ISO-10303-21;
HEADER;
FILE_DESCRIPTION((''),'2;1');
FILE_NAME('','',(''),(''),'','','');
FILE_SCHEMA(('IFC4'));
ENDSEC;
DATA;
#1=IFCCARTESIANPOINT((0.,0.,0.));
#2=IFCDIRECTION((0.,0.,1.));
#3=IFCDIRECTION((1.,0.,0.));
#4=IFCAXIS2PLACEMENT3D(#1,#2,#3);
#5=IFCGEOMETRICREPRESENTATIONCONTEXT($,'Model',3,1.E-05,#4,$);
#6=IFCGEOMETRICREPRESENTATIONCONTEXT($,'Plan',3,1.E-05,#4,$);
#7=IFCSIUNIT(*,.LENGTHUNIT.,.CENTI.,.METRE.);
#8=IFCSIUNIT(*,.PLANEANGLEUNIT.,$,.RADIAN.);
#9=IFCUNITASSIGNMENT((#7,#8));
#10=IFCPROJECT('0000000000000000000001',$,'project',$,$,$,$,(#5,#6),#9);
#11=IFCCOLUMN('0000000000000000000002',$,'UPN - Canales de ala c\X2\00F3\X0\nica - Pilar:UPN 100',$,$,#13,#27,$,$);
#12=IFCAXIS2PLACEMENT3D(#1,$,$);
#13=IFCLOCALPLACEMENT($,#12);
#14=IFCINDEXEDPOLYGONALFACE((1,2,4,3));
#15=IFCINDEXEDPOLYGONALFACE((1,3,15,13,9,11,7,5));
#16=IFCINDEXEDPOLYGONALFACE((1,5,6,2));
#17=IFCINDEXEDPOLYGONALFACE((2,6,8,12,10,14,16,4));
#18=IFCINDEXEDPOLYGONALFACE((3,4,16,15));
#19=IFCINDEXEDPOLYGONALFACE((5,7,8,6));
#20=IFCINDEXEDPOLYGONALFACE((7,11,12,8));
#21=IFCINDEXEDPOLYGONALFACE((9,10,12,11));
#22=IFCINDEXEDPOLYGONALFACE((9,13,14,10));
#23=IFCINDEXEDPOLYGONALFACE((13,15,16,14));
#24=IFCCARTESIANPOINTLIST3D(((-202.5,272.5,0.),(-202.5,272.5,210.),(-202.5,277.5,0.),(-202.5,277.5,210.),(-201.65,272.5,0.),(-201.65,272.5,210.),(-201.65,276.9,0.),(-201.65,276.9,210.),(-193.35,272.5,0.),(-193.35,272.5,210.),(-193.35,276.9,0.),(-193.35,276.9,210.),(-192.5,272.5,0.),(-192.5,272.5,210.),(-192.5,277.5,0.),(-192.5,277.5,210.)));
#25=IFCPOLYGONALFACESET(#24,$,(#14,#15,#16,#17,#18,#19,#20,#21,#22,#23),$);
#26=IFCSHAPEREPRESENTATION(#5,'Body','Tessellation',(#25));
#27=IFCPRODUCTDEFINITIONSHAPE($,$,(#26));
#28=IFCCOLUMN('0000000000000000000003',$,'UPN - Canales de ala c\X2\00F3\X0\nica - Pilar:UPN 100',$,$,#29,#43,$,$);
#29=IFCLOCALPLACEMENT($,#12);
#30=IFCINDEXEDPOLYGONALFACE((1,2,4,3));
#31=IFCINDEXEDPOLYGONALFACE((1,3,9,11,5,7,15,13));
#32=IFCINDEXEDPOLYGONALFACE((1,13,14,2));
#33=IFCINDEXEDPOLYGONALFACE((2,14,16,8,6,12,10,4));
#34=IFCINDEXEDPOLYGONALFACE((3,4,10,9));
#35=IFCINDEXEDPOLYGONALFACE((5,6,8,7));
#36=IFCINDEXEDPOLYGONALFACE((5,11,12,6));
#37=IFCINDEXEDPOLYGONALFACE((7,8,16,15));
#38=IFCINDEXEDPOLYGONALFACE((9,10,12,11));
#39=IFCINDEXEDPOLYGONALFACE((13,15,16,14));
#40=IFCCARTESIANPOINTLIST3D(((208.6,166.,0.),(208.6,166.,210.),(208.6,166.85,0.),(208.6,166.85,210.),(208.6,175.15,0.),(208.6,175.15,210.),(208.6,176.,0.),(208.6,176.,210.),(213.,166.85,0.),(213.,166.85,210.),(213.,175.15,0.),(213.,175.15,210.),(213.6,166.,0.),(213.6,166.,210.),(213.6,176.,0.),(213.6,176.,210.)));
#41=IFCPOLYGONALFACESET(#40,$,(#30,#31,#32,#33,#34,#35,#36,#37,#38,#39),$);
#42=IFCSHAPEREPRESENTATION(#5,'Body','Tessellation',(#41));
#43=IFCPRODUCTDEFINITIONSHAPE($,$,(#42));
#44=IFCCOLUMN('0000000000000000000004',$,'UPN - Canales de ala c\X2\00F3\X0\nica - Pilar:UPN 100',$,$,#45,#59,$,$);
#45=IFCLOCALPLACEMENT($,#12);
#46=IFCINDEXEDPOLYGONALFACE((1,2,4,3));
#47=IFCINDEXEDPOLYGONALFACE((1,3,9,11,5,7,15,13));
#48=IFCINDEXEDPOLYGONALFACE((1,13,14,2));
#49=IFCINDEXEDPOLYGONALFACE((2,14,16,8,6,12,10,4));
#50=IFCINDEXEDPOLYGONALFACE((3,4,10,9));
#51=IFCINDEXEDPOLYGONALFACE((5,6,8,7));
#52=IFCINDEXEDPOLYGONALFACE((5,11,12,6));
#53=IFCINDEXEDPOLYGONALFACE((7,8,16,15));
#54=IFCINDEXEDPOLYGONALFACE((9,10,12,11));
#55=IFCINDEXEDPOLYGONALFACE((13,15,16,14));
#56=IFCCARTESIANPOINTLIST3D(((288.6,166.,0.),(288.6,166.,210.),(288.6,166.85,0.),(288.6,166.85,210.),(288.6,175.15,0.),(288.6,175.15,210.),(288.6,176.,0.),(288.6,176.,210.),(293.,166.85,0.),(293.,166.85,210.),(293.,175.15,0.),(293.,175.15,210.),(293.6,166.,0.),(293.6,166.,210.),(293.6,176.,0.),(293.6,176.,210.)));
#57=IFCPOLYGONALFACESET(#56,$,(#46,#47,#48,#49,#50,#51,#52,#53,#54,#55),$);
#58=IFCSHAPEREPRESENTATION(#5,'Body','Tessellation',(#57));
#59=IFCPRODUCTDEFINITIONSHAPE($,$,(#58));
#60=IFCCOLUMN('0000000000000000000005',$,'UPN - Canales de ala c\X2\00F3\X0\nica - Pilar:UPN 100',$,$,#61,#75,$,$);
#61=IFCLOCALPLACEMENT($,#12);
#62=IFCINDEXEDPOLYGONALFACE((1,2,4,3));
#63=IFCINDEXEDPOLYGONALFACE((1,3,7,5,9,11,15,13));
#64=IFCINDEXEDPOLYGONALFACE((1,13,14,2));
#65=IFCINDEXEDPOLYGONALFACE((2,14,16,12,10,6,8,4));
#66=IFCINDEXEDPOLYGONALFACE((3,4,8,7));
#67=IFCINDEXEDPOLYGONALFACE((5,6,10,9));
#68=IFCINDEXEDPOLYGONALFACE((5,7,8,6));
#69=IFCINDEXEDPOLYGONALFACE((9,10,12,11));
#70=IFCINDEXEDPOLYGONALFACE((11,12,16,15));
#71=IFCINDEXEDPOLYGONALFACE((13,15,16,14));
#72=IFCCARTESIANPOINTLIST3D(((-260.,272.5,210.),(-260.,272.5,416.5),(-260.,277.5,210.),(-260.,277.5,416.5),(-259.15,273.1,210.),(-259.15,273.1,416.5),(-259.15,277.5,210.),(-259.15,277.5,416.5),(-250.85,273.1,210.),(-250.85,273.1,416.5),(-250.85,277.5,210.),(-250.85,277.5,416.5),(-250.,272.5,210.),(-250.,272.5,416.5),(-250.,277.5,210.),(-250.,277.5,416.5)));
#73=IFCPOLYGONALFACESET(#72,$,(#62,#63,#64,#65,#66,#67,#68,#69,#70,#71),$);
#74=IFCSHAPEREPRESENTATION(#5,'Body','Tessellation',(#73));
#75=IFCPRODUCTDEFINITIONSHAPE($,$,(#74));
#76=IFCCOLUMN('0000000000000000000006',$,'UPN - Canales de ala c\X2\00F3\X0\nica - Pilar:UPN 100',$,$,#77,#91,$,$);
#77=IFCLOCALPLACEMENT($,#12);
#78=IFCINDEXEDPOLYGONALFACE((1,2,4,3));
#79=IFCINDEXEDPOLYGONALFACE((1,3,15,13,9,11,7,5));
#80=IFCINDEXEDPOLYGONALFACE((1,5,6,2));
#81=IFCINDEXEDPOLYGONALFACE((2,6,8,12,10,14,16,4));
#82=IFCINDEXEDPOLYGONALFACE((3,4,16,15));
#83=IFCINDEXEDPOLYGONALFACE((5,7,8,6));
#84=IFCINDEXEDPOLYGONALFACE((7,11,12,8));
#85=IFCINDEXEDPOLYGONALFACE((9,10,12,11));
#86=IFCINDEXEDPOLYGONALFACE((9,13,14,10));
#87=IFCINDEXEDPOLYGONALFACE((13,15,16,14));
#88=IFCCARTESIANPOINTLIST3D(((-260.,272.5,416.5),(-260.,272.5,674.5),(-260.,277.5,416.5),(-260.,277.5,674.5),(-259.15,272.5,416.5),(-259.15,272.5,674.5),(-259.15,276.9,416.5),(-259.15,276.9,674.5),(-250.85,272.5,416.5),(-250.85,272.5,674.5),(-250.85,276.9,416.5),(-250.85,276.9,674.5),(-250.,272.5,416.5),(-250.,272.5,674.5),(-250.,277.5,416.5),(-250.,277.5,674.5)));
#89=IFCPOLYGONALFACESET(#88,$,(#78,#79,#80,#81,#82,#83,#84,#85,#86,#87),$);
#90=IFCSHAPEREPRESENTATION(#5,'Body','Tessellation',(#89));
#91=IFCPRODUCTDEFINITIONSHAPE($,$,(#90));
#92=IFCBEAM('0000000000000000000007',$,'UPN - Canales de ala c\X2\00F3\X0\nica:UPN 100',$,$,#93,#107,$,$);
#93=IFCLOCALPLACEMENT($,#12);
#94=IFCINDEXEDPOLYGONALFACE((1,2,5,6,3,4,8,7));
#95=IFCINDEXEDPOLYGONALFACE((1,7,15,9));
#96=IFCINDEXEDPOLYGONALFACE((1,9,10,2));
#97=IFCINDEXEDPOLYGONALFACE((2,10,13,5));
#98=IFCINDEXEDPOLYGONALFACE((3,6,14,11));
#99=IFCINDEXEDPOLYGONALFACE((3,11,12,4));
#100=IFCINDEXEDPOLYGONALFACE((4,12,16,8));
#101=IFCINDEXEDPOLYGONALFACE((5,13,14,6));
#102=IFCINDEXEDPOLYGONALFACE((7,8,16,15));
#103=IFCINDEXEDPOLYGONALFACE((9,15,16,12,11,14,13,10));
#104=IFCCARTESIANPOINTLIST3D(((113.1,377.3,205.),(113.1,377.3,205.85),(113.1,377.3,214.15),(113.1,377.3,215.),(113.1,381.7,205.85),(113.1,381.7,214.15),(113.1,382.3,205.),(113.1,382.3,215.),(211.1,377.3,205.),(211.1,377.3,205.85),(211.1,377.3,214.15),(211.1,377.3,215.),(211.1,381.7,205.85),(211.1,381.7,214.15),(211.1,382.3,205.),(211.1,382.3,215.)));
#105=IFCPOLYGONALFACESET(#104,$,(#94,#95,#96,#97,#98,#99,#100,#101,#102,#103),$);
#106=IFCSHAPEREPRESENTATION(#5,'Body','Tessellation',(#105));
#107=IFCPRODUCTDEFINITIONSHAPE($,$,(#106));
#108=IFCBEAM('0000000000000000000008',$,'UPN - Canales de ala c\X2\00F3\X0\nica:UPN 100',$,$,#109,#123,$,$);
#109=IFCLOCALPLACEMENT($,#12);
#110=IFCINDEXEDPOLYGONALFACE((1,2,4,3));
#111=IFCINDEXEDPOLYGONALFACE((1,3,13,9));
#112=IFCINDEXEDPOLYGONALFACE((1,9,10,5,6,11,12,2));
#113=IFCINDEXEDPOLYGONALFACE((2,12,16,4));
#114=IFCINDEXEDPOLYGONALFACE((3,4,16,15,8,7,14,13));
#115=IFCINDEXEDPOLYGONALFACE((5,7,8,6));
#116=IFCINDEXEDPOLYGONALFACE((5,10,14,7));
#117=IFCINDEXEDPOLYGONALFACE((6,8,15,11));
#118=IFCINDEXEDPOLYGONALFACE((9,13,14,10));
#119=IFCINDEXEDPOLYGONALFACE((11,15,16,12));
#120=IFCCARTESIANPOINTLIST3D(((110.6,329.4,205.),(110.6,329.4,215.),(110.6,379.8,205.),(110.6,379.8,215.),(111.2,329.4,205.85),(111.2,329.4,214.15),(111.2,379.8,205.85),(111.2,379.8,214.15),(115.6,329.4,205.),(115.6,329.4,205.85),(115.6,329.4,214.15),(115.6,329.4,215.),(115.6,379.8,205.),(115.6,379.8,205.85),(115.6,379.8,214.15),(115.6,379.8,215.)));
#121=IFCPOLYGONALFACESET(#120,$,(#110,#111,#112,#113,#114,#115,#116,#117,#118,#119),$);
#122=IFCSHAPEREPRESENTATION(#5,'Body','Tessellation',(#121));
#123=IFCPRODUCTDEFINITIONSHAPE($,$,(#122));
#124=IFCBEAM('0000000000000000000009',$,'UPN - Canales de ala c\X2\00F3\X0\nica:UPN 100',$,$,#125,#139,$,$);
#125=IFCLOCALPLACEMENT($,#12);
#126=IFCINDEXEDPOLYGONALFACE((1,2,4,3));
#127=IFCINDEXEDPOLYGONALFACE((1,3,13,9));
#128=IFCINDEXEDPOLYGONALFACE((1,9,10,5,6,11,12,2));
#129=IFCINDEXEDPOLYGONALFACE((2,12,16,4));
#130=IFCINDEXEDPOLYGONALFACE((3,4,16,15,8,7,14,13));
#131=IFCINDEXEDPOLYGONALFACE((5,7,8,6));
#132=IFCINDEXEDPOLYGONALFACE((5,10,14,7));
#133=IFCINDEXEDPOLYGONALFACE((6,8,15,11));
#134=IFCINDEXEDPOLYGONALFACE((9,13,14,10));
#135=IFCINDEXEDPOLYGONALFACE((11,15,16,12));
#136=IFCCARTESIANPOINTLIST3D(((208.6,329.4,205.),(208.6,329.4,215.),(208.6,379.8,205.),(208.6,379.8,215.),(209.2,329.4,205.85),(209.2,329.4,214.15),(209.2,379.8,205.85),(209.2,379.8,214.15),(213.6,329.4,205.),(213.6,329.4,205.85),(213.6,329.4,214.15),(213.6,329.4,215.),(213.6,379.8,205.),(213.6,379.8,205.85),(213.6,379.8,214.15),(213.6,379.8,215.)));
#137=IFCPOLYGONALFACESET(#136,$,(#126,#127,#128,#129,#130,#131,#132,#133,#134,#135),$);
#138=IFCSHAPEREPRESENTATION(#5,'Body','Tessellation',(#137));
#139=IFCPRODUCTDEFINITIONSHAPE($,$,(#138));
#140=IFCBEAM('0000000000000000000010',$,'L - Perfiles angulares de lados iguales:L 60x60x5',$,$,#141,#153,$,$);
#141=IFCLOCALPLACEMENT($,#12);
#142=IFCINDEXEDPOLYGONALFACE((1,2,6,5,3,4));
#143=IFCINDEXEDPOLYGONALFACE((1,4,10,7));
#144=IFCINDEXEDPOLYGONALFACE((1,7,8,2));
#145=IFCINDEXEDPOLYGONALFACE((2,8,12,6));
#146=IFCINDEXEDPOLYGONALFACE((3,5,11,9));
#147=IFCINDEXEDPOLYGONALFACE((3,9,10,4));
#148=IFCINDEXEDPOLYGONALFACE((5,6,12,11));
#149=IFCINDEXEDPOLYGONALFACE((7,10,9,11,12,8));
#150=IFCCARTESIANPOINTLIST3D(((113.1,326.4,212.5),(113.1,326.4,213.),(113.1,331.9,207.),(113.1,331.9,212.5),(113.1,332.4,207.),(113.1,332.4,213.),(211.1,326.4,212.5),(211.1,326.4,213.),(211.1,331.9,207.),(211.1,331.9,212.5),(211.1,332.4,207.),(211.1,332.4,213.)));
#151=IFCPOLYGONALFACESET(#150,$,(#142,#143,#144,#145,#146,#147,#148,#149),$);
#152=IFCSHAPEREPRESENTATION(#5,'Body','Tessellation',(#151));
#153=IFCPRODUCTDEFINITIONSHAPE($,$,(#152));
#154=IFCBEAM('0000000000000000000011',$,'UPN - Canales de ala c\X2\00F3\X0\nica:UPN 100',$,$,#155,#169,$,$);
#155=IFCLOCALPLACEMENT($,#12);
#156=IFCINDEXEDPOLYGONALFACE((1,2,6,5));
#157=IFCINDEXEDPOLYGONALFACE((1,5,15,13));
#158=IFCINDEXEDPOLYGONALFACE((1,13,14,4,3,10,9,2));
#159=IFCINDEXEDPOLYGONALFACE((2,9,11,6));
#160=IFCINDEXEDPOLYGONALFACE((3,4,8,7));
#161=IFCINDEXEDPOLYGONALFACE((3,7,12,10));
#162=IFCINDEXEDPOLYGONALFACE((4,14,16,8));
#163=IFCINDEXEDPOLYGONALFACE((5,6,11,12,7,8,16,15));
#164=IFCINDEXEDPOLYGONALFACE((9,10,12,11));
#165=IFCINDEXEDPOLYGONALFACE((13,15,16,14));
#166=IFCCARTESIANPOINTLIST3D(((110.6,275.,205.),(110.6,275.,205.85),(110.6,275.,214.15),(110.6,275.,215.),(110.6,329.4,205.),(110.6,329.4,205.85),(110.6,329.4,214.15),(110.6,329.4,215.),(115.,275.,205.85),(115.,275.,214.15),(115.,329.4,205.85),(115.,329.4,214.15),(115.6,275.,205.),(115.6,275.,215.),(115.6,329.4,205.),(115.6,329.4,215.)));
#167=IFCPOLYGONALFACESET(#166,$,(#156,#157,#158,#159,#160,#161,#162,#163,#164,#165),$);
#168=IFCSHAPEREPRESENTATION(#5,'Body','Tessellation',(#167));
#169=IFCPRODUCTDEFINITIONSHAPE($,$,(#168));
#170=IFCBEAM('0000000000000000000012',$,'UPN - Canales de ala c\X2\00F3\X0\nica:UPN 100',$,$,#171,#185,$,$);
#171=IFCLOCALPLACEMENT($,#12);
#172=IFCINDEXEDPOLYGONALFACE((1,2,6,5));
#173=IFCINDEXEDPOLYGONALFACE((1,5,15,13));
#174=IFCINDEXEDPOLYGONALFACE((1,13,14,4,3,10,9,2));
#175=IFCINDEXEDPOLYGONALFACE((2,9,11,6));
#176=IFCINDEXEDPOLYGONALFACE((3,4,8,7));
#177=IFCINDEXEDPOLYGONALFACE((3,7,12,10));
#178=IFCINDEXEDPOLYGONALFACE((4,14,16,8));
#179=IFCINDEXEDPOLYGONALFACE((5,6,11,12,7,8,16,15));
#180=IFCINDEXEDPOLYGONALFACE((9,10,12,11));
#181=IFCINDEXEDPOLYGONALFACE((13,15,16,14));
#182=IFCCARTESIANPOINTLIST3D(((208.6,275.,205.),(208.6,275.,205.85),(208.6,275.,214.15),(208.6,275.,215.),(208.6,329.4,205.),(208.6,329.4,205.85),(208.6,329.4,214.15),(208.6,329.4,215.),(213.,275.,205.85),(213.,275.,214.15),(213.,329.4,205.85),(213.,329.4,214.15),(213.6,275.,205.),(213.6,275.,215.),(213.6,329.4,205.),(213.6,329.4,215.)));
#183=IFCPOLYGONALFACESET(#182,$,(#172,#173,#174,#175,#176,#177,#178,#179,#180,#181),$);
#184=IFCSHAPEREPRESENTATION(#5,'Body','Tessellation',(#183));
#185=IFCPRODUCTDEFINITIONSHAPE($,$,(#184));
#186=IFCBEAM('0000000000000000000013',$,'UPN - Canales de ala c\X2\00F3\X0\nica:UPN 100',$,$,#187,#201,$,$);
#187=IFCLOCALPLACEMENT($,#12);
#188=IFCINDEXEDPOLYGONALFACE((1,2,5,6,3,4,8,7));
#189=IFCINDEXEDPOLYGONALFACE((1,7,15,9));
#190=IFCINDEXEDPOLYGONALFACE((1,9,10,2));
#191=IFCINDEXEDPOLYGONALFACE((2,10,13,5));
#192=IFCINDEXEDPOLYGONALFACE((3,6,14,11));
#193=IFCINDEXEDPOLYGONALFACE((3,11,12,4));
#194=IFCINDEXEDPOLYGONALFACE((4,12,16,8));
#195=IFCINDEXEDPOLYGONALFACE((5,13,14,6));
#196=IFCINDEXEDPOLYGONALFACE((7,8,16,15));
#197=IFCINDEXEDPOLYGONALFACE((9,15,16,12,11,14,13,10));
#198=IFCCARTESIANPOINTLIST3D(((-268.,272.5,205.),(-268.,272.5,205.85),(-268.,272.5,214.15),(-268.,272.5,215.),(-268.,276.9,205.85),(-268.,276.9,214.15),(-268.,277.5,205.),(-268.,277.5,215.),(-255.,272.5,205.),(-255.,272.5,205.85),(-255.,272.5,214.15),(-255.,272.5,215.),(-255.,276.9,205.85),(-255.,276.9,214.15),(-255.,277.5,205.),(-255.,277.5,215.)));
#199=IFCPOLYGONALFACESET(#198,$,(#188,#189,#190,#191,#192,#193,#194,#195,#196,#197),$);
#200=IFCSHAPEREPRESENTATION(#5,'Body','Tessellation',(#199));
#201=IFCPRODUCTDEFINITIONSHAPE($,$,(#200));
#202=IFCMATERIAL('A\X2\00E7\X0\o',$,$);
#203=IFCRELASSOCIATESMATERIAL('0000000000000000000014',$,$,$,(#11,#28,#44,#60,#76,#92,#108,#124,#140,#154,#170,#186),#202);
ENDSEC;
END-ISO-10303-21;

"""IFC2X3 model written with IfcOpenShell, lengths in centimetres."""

from ifc_helpers import new_model, si_unit, frame, origin_with_axes, origin_2d_with_axis, place, context, project, polyline, u_section, outline, extrude, material, element, save


model = new_model("IFC2X3")

# Units and contexts
model_context = context("Model", 3, precision=1e-05, world=origin_with_axes())
plan_context = context("Plan", 3, precision=1e-05, world=origin_with_axes())
ifc_project = project(units=[si_unit("LENGTHUNIT", "METRE", prefix="CENTI"), si_unit("PLANEANGLEUNIT", "RADIAN")], contexts=[model_context, plan_context])

# Columns
ifc_material = material(Name="Aço")
for number, where, z_axis, x_axis, name in (
    (1, (-197.5, 275.0, 0.0), (0.0, 0.0, 1.0), (0.0, -1.0, 0.0), "UPN - Canales de ala cónica - Pilar:UPN 100"),
    (2, (211.1, 171.0, 0.0), (0.0, 0.0, 1.0), (-1.0, 0.0, 0.0), "UPN - Canales de ala cónica - Pilar:UPN 100"),
    (3, (291.1, 171.0, 0.0), (0.0, 0.0, 1.0), (-1.0, 0.0, 0.0), "UPN - Canales de ala cónica - Pilar:UPN 100"),
):
    element("IfcColumn", number, at=place(None, frame(where, z_axis=z_axis, x_axis=x_axis)), material=ifc_material, Name=name, context=model_context, shape_type="SweptSolid", body=[
        extrude(u_section(Depth=10.0, FlangeWidth=5.0, WebThickness=0.6, FlangeThickness=0.85, FilletRadius=0.0, EdgeRadius=0.0, FlangeSlope=0.0, CentreOfGravityInX=0.0, at=origin_2d_with_axis()), origin_with_axes(), (0.0, 0.0, 1.0), 210.0),
    ])
column_1_placement = place(None, frame((-255.0, 275.0, 210.0), z_axis=(0.0, 0.0, 1.0), x_axis=(0.0, 1.0, 0.0)))
element("IfcColumn", 4, at=column_1_placement, material=ifc_material, Name="UPN - Canales de ala cónica - Pilar:UPN 100", context=model_context, shape_type="SweptSolid", body=[
    extrude(u_section(Depth=10.0, FlangeWidth=5.0, WebThickness=0.6, FlangeThickness=0.85, FilletRadius=0.0, EdgeRadius=0.0, FlangeSlope=0.0, CentreOfGravityInX=0.0, at=origin_2d_with_axis()), origin_with_axes(), (0.0, 0.0, 1.0), 206.5),
])
column_2_placement = place(None, frame((-255.0, 275.0, 416.5), z_axis=(0.0, 0.0, 1.0), x_axis=(0.0, -1.0, 0.0)))
element("IfcColumn", 5, at=column_2_placement, material=ifc_material, Name="UPN - Canales de ala cónica - Pilar:UPN 100", context=model_context, shape_type="SweptSolid", body=[
    extrude(u_section(Depth=10.0, FlangeWidth=5.0, WebThickness=0.6, FlangeThickness=0.85, FilletRadius=0.0, EdgeRadius=0.0, FlangeSlope=0.0, CentreOfGravityInX=0.0, at=origin_2d_with_axis()), origin_with_axes(), (0.0, 0.0, 1.0), 258.0),
])

# Beams
beam_1_placement = place(None, frame((211.1, 379.8, 210.0), z_axis=(-1.0, 0.0, 0.0), x_axis=(0.0, -1.0, 0.0)))
element("IfcBeam", 6, at=beam_1_placement, material=ifc_material, Name="UPN - Canales de ala cónica:UPN 100", context=model_context, shape_type="SweptSolid", body=[
    extrude(u_section(Depth=10.0, FlangeWidth=5.0, WebThickness=0.6, FlangeThickness=0.85, FilletRadius=0.0, EdgeRadius=0.0, FlangeSlope=0.0, CentreOfGravityInX=0.0, at=origin_2d_with_axis()), origin_with_axes(), (0.0, 0.0, 1.0), 98.0),
])
for number, where, z_axis, x_axis, name in (
    (7, (113.1, 329.4, 210.0), (0.0, 1.0, 0.0), (1.0, 0.0, 0.0), "UPN - Canales de ala cónica:UPN 100"),
    (8, (211.1, 329.4, 210.0), (0.0, 1.0, 0.0), (1.0, 0.0, 0.0), "UPN - Canales de ala cónica:UPN 100"),
):
    element("IfcBeam", number, at=place(None, frame(where, z_axis=z_axis, x_axis=x_axis)), material=ifc_material, Name=name, context=model_context, shape_type="SweptSolid", body=[
        extrude(u_section(Depth=10.0, FlangeWidth=5.0, WebThickness=0.6, FlangeThickness=0.85, FilletRadius=0.0, EdgeRadius=0.0, FlangeSlope=0.0, CentreOfGravityInX=0.0, at=origin_2d_with_axis()), origin_with_axes(), (0.0, 0.0, 1.0), 50.4),
    ])
beam_2_placement = place(None, frame((211.1, 329.4, 210.0), z_axis=(-1.0, 0.0, 0.0), x_axis=(0.0, 0.0, 1.0)))
element("IfcBeam", 9, at=beam_2_placement, material=ifc_material, Name="L - Perfiles angulares de lados iguales:L 60x60x5", context=model_context, shape_type="SweptSolid", body=[
    extrude(outline(polyline([(3.0, -3.0), (3.0, 3.0), (-3.0, 3.0), (-3.0, 2.5), (2.5, 2.5), (2.5, -3.0), (3.0, -3.0)])), origin_with_axes(), (0.0, 0.0, 1.0), 98.0),
])
for number, where, z_axis, x_axis, name in (
    (10, (113.1, 275.0, 210.0), (0.0, 1.0, 0.0), (-1.0, 0.0, 0.0), "UPN - Canales de ala cónica:UPN 100"),
    (11, (211.1, 275.0, 210.0), (0.0, 1.0, 0.0), (-1.0, 0.0, 0.0), "UPN - Canales de ala cónica:UPN 100"),
):
    element("IfcBeam", number, at=place(None, frame(where, z_axis=z_axis, x_axis=x_axis)), material=ifc_material, Name=name, context=model_context, shape_type="SweptSolid", body=[
        extrude(u_section(Depth=10.0, FlangeWidth=5.0, WebThickness=0.6, FlangeThickness=0.85, FilletRadius=0.0, EdgeRadius=0.0, FlangeSlope=0.0, CentreOfGravityInX=0.0, at=origin_2d_with_axis()), origin_with_axes(), (0.0, 0.0, 1.0), 54.4),
    ])
beam_3_placement = place(None, frame((-255.0, 275.0, 210.0), z_axis=(-1.0, 0.0, 0.0), x_axis=(0.0, -1.0, 0.0)))
element("IfcBeam", 12, at=beam_3_placement, material=ifc_material, Name="UPN - Canales de ala cónica:UPN 100", context=model_context, shape_type="SweptSolid", body=[
    extrude(u_section(Depth=10.0, FlangeWidth=5.0, WebThickness=0.6, FlangeThickness=0.85, FilletRadius=0.0, EdgeRadius=0.0, FlangeSlope=0.0, CentreOfGravityInX=0.0, at=origin_2d_with_axis()), origin_with_axes(), (0.0, 0.0, 1.0), 13.0),
])

save(model, "model.ifc")
